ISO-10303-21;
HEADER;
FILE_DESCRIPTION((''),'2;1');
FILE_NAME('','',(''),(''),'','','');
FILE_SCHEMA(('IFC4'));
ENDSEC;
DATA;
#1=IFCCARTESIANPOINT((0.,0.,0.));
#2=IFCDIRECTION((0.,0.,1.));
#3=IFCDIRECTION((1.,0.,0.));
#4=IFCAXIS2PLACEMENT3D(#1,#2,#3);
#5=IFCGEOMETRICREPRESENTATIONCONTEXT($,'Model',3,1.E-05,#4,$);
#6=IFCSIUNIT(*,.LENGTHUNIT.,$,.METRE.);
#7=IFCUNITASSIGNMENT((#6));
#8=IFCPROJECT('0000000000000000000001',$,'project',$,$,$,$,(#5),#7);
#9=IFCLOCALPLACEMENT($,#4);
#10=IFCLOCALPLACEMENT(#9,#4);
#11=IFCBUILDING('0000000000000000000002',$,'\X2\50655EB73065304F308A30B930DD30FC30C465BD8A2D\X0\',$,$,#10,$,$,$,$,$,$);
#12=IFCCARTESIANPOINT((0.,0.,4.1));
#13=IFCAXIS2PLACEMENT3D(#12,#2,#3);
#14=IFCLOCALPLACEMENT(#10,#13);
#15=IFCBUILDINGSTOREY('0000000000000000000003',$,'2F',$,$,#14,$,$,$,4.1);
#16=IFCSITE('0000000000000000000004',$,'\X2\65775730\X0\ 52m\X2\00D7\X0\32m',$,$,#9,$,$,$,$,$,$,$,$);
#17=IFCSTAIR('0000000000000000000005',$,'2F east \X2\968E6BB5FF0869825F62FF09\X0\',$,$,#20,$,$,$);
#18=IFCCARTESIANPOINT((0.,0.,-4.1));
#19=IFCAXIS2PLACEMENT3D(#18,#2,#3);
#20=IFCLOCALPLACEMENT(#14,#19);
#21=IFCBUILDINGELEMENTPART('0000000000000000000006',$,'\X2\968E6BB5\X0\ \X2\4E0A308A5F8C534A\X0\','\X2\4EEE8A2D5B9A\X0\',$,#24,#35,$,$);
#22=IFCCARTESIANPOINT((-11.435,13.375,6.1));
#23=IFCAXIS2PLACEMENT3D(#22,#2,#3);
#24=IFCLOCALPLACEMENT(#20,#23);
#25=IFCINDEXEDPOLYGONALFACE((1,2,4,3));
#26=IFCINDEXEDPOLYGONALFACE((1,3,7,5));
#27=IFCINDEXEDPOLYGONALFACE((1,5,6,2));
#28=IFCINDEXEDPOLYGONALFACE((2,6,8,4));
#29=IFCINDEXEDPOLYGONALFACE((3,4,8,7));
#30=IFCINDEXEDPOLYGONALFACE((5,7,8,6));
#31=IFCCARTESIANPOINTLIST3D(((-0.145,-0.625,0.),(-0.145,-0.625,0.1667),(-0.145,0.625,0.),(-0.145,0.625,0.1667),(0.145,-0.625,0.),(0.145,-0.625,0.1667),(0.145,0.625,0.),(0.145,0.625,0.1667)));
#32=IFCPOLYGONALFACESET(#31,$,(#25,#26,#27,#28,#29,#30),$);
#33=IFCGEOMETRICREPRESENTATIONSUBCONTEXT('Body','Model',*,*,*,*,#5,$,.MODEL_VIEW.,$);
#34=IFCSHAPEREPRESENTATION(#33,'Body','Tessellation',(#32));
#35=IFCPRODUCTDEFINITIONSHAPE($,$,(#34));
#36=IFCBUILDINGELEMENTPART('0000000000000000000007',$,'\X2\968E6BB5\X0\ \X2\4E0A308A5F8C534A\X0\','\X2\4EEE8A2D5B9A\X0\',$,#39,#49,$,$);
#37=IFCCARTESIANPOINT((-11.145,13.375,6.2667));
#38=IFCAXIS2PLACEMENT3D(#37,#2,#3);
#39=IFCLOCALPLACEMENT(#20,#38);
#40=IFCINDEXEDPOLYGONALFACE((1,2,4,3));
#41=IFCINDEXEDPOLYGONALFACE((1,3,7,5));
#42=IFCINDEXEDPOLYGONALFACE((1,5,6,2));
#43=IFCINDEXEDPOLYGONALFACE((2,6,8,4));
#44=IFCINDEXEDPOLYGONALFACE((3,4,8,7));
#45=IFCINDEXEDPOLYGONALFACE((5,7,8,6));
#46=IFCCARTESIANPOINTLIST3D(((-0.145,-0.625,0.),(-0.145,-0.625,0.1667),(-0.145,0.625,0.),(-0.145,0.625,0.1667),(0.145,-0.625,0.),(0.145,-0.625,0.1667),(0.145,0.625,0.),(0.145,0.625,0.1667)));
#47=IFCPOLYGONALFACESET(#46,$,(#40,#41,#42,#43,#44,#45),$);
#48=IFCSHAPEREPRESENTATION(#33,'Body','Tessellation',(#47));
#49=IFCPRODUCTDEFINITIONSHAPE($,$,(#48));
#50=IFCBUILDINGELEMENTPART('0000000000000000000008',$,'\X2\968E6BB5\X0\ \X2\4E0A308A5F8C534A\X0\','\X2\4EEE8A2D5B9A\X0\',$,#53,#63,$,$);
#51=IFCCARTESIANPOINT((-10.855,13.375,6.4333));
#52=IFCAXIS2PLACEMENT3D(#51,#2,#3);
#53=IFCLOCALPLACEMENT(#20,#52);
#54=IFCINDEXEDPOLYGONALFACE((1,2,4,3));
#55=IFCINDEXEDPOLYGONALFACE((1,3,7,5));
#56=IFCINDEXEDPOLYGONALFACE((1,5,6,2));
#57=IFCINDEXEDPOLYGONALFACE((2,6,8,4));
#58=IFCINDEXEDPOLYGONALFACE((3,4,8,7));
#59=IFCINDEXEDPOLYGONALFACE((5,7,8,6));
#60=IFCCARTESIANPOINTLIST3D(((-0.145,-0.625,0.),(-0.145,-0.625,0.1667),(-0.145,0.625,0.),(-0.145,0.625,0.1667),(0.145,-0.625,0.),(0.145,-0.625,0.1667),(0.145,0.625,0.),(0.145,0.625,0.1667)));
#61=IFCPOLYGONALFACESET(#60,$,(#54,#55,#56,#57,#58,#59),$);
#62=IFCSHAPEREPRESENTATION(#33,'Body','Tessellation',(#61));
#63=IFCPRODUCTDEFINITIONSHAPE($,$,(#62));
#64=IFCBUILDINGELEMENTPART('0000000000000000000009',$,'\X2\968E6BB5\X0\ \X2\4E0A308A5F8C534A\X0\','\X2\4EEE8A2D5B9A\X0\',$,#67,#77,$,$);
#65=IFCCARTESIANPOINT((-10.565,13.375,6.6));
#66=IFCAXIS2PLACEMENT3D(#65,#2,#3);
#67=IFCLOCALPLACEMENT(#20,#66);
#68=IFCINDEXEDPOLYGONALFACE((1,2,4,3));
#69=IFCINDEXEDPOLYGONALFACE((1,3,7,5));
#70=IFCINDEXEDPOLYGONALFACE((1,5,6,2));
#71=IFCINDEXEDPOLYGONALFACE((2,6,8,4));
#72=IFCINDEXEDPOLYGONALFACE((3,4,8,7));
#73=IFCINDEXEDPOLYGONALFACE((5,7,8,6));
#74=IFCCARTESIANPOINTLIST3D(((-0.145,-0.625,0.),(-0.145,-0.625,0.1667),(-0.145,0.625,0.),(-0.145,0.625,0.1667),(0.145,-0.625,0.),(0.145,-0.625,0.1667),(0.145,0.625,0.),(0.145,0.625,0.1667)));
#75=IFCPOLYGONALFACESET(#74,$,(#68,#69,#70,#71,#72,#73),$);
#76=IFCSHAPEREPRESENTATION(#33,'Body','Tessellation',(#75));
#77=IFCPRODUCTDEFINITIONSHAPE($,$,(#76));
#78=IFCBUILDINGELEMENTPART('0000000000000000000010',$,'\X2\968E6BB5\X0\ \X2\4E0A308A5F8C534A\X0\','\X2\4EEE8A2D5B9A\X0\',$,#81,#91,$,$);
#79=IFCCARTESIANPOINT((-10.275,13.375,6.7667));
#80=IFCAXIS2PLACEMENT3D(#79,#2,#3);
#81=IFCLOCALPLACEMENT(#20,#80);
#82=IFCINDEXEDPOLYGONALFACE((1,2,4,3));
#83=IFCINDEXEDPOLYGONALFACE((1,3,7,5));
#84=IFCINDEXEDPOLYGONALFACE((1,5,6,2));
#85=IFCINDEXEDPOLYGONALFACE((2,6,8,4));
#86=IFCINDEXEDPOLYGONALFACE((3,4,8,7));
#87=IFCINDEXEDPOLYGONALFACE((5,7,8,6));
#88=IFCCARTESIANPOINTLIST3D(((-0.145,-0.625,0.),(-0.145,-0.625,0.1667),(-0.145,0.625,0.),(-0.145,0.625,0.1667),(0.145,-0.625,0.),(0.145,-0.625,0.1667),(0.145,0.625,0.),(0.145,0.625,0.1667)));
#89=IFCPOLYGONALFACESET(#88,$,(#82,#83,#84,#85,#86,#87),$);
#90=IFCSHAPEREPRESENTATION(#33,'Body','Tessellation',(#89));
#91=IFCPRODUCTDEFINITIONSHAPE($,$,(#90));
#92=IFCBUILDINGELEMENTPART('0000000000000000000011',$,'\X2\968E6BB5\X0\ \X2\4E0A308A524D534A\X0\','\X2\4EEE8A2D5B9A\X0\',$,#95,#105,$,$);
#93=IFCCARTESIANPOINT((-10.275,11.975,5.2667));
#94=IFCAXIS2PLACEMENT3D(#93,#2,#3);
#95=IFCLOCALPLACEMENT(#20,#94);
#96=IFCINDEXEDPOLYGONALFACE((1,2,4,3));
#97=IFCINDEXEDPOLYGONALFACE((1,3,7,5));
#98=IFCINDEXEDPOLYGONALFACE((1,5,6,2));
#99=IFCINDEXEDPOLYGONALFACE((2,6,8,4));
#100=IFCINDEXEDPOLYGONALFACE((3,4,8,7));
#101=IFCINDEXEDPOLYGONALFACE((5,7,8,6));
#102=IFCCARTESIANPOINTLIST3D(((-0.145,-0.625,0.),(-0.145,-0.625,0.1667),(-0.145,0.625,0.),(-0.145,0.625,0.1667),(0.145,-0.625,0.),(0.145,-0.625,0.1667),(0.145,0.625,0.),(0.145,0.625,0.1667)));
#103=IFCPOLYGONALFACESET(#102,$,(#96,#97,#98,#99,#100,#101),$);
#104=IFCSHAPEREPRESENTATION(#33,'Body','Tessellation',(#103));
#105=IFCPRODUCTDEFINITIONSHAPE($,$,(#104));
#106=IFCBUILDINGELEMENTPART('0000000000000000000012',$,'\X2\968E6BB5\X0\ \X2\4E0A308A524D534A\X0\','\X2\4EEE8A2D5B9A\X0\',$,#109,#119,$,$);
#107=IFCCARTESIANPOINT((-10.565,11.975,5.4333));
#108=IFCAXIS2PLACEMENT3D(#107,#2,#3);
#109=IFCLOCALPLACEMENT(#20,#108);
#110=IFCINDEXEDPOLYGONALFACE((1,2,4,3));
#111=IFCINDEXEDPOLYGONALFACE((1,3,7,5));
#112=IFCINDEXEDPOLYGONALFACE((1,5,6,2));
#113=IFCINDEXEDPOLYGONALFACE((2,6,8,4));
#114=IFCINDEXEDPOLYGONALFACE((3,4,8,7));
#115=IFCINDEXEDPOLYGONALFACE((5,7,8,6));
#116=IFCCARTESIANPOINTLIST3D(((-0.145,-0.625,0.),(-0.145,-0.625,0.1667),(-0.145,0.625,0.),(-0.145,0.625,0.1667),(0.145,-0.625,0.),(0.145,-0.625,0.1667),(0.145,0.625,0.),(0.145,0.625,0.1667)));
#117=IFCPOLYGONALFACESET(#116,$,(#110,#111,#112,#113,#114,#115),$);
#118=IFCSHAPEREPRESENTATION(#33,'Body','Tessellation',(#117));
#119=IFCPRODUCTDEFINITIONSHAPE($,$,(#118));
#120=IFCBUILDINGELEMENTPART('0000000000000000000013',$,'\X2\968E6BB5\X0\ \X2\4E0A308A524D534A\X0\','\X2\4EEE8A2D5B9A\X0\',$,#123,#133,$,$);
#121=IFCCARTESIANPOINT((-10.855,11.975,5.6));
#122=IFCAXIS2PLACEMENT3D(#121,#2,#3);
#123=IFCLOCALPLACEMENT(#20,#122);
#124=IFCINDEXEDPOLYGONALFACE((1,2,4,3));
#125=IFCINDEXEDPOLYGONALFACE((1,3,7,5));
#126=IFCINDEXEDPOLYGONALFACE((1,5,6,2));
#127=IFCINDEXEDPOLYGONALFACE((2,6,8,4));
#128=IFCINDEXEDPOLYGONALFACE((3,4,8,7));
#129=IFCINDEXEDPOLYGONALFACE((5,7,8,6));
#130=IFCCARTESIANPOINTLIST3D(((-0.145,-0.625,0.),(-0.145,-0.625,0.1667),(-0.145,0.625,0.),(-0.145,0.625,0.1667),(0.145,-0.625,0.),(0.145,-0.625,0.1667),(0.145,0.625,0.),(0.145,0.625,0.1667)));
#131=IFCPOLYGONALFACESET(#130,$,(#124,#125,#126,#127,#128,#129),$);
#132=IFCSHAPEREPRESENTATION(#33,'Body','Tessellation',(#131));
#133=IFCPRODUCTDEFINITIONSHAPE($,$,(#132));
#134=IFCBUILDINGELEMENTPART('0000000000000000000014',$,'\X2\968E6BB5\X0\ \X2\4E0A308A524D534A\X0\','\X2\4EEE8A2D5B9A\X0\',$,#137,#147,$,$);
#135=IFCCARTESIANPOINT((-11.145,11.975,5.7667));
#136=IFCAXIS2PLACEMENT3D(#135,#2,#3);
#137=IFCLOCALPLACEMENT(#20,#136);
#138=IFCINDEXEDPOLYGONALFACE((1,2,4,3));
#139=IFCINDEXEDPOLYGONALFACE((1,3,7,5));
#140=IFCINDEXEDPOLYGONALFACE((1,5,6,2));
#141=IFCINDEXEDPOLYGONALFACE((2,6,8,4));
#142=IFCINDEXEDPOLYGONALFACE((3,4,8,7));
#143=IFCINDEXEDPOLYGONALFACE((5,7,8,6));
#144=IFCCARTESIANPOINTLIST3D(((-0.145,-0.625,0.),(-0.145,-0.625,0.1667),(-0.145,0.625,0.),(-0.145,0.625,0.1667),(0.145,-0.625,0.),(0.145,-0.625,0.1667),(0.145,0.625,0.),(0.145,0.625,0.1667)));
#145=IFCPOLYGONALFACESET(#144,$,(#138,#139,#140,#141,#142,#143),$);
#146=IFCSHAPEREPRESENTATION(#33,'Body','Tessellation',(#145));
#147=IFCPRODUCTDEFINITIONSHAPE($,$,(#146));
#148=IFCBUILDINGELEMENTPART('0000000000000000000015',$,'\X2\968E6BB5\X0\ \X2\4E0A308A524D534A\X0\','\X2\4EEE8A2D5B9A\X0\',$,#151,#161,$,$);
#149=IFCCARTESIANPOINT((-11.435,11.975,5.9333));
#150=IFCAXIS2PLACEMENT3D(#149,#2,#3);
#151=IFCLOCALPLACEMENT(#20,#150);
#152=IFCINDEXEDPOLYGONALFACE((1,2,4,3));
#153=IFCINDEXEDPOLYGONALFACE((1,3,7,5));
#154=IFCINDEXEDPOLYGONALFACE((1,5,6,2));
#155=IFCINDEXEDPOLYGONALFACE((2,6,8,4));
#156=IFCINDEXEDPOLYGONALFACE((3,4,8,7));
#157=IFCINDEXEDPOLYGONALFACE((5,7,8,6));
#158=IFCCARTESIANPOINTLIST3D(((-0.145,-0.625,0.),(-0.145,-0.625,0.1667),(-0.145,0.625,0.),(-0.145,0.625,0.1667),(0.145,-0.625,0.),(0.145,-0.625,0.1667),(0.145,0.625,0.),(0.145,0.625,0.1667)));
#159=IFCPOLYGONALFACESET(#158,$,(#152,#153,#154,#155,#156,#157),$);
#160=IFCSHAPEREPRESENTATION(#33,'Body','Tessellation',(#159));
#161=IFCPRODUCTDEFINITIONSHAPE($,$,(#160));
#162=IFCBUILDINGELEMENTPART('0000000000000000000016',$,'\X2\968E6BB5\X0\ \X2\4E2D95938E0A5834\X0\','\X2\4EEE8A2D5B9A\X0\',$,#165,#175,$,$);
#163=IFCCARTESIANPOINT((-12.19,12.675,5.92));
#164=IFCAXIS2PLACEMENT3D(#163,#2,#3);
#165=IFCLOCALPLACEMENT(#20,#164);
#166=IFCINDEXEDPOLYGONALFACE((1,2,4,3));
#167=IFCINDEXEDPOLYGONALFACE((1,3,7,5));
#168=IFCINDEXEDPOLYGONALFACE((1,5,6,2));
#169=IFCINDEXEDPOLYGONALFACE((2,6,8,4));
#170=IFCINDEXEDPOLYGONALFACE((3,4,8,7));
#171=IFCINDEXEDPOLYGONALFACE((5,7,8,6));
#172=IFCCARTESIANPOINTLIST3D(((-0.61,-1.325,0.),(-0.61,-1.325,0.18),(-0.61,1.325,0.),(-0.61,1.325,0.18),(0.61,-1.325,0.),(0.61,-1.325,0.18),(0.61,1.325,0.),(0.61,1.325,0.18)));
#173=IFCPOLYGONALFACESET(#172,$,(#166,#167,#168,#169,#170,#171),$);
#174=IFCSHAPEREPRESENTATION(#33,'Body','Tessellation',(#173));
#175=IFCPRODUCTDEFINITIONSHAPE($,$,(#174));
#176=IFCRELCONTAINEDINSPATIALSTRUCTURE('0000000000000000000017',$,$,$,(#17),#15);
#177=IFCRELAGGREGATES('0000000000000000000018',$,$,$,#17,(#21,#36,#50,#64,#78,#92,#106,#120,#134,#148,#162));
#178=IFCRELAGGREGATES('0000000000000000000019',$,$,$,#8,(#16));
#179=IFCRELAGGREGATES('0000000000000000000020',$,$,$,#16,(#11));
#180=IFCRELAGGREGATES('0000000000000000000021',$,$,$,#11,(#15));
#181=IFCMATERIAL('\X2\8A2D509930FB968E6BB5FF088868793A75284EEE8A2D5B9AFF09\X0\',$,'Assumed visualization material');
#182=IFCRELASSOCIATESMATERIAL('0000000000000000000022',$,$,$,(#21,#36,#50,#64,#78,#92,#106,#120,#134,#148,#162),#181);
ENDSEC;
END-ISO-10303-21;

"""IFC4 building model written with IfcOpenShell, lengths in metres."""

from ifc_helpers import new_model, si_unit, frame, origin_with_axes, place, context, subcontext, project, spatial, rectangle, extrude, material, element, aggregate, save


model = new_model("IFC4")

# Units and contexts
model_context = context("Model", 3, precision=1e-05, world=origin_with_axes())
body_context = subcontext(model_context, "Body", "Model", "MODEL_VIEW")
ifc_project = project(units=[si_unit("LENGTHUNIT", "METRE")], contexts=[model_context])

# Site, building, storey
site_placement = place(None, origin_with_axes())
site = spatial("IfcSite", under=ifc_project, at=site_placement, Name="敷地 52m×32m")
building_placement = place(site_placement, origin_with_axes())
building = spatial("IfcBuilding", under=site, at=building_placement, Name="健康づくりスポーツ施設")
storey_placement = place(building_placement, frame((0.0, 0.0, 4.1), z_axis=(0.0, 0.0, 1.0), x_axis=(1.0, 0.0, 0.0)))
storey = spatial("IfcBuildingStorey", under=building, at=storey_placement, Name="2F", Elevation=4.1)

# Stair, building element parts
stair_placement = place(storey_placement, frame((0.0, 0.0, -4.1), z_axis=(0.0, 0.0, 1.0), x_axis=(1.0, 0.0, 0.0)))
stair = element("IfcStair", 1, at=stair_placement, inside=storey, Name="2F east 階段（概形）")
ifc_material_1 = material(Name="設備・階段（表示用仮設定）", Category="Assumed visualization material")
building_element_part_1_placement = place(stair_placement, frame((-11.435, 13.375, 6.1), z_axis=(0.0, 0.0, 1.0), x_axis=(1.0, 0.0, 0.0)))
building_element_part_1 = element("IfcBuildingElementPart", 2, at=building_element_part_1_placement, material=ifc_material_1, Name="階段 上り後半", Description="仮設定", context=body_context, shape_type="SweptSolid", body=[
    extrude(rectangle(XDim=0.29, YDim=1.25), origin_with_axes(), (0.0, 0.0, 1.0), 0.1667),
])
building_element_part_2_placement = place(stair_placement, frame((-11.145, 13.375, 6.2667), z_axis=(0.0, 0.0, 1.0), x_axis=(1.0, 0.0, 0.0)))
building_element_part_2 = element("IfcBuildingElementPart", 3, at=building_element_part_2_placement, material=ifc_material_1, Name="階段 上り後半", Description="仮設定", context=body_context, shape_type="SweptSolid", body=[
    extrude(rectangle(XDim=0.29, YDim=1.25), origin_with_axes(), (0.0, 0.0, 1.0), 0.1667),
])
building_element_part_3_placement = place(stair_placement, frame((-10.855, 13.375, 6.4333), z_axis=(0.0, 0.0, 1.0), x_axis=(1.0, 0.0, 0.0)))
building_element_part_3 = element("IfcBuildingElementPart", 4, at=building_element_part_3_placement, material=ifc_material_1, Name="階段 上り後半", Description="仮設定", context=body_context, shape_type="SweptSolid", body=[
    extrude(rectangle(XDim=0.29, YDim=1.25), origin_with_axes(), (0.0, 0.0, 1.0), 0.1667),
])
building_element_part_4_placement = place(stair_placement, frame((-10.565, 13.375, 6.6), z_axis=(0.0, 0.0, 1.0), x_axis=(1.0, 0.0, 0.0)))
building_element_part_4 = element("IfcBuildingElementPart", 5, at=building_element_part_4_placement, material=ifc_material_1, Name="階段 上り後半", Description="仮設定", context=body_context, shape_type="SweptSolid", body=[
    extrude(rectangle(XDim=0.29, YDim=1.25), origin_with_axes(), (0.0, 0.0, 1.0), 0.1667),
])
building_element_part_5_placement = place(stair_placement, frame((-10.275, 13.375, 6.7667), z_axis=(0.0, 0.0, 1.0), x_axis=(1.0, 0.0, 0.0)))
building_element_part_5 = element("IfcBuildingElementPart", 6, at=building_element_part_5_placement, material=ifc_material_1, Name="階段 上り後半", Description="仮設定", context=body_context, shape_type="SweptSolid", body=[
    extrude(rectangle(XDim=0.29, YDim=1.25), origin_with_axes(), (0.0, 0.0, 1.0), 0.1667),
])
building_element_part_6_placement = place(stair_placement, frame((-10.275, 11.975, 5.2667), z_axis=(0.0, 0.0, 1.0), x_axis=(1.0, 0.0, 0.0)))
building_element_part_6 = element("IfcBuildingElementPart", 7, at=building_element_part_6_placement, material=ifc_material_1, Name="階段 上り前半", Description="仮設定", context=body_context, shape_type="SweptSolid", body=[
    extrude(rectangle(XDim=0.29, YDim=1.25), origin_with_axes(), (0.0, 0.0, 1.0), 0.1667),
])
building_element_part_7_placement = place(stair_placement, frame((-10.565, 11.975, 5.4333), z_axis=(0.0, 0.0, 1.0), x_axis=(1.0, 0.0, 0.0)))
building_element_part_7 = element("IfcBuildingElementPart", 8, at=building_element_part_7_placement, material=ifc_material_1, Name="階段 上り前半", Description="仮設定", context=body_context, shape_type="SweptSolid", body=[
    extrude(rectangle(XDim=0.29, YDim=1.25), origin_with_axes(), (0.0, 0.0, 1.0), 0.1667),
])
building_element_part_8_placement = place(stair_placement, frame((-10.855, 11.975, 5.6), z_axis=(0.0, 0.0, 1.0), x_axis=(1.0, 0.0, 0.0)))
building_element_part_8 = element("IfcBuildingElementPart", 9, at=building_element_part_8_placement, material=ifc_material_1, Name="階段 上り前半", Description="仮設定", context=body_context, shape_type="SweptSolid", body=[
    extrude(rectangle(XDim=0.29, YDim=1.25), origin_with_axes(), (0.0, 0.0, 1.0), 0.1667),
])
building_element_part_9_placement = place(stair_placement, frame((-11.145, 11.975, 5.7667), z_axis=(0.0, 0.0, 1.0), x_axis=(1.0, 0.0, 0.0)))
building_element_part_9 = element("IfcBuildingElementPart", 10, at=building_element_part_9_placement, material=ifc_material_1, Name="階段 上り前半", Description="仮設定", context=body_context, shape_type="SweptSolid", body=[
    extrude(rectangle(XDim=0.29, YDim=1.25), origin_with_axes(), (0.0, 0.0, 1.0), 0.1667),
])
building_element_part_10_placement = place(stair_placement, frame((-11.435, 11.975, 5.9333), z_axis=(0.0, 0.0, 1.0), x_axis=(1.0, 0.0, 0.0)))
building_element_part_10 = element("IfcBuildingElementPart", 11, at=building_element_part_10_placement, material=ifc_material_1, Name="階段 上り前半", Description="仮設定", context=body_context, shape_type="SweptSolid", body=[
    extrude(rectangle(XDim=0.29, YDim=1.25), origin_with_axes(), (0.0, 0.0, 1.0), 0.1667),
])
building_element_part_11_placement = place(stair_placement, frame((-12.19, 12.675, 5.92), z_axis=(0.0, 0.0, 1.0), x_axis=(1.0, 0.0, 0.0)))
building_element_part_11 = element("IfcBuildingElementPart", 12, at=building_element_part_11_placement, material=ifc_material_1, Name="階段 中間踊場", Description="仮設定", context=body_context, shape_type="SweptSolid", body=[
    extrude(rectangle(XDim=1.22, YDim=2.65), origin_with_axes(), (0.0, 0.0, 1.0), 0.18),
])
aggregate(stair, [building_element_part_1, building_element_part_2, building_element_part_3, building_element_part_4, building_element_part_5, building_element_part_6, building_element_part_7, building_element_part_8, building_element_part_9, building_element_part_10, building_element_part_11])

save(model, "model.ifc")
